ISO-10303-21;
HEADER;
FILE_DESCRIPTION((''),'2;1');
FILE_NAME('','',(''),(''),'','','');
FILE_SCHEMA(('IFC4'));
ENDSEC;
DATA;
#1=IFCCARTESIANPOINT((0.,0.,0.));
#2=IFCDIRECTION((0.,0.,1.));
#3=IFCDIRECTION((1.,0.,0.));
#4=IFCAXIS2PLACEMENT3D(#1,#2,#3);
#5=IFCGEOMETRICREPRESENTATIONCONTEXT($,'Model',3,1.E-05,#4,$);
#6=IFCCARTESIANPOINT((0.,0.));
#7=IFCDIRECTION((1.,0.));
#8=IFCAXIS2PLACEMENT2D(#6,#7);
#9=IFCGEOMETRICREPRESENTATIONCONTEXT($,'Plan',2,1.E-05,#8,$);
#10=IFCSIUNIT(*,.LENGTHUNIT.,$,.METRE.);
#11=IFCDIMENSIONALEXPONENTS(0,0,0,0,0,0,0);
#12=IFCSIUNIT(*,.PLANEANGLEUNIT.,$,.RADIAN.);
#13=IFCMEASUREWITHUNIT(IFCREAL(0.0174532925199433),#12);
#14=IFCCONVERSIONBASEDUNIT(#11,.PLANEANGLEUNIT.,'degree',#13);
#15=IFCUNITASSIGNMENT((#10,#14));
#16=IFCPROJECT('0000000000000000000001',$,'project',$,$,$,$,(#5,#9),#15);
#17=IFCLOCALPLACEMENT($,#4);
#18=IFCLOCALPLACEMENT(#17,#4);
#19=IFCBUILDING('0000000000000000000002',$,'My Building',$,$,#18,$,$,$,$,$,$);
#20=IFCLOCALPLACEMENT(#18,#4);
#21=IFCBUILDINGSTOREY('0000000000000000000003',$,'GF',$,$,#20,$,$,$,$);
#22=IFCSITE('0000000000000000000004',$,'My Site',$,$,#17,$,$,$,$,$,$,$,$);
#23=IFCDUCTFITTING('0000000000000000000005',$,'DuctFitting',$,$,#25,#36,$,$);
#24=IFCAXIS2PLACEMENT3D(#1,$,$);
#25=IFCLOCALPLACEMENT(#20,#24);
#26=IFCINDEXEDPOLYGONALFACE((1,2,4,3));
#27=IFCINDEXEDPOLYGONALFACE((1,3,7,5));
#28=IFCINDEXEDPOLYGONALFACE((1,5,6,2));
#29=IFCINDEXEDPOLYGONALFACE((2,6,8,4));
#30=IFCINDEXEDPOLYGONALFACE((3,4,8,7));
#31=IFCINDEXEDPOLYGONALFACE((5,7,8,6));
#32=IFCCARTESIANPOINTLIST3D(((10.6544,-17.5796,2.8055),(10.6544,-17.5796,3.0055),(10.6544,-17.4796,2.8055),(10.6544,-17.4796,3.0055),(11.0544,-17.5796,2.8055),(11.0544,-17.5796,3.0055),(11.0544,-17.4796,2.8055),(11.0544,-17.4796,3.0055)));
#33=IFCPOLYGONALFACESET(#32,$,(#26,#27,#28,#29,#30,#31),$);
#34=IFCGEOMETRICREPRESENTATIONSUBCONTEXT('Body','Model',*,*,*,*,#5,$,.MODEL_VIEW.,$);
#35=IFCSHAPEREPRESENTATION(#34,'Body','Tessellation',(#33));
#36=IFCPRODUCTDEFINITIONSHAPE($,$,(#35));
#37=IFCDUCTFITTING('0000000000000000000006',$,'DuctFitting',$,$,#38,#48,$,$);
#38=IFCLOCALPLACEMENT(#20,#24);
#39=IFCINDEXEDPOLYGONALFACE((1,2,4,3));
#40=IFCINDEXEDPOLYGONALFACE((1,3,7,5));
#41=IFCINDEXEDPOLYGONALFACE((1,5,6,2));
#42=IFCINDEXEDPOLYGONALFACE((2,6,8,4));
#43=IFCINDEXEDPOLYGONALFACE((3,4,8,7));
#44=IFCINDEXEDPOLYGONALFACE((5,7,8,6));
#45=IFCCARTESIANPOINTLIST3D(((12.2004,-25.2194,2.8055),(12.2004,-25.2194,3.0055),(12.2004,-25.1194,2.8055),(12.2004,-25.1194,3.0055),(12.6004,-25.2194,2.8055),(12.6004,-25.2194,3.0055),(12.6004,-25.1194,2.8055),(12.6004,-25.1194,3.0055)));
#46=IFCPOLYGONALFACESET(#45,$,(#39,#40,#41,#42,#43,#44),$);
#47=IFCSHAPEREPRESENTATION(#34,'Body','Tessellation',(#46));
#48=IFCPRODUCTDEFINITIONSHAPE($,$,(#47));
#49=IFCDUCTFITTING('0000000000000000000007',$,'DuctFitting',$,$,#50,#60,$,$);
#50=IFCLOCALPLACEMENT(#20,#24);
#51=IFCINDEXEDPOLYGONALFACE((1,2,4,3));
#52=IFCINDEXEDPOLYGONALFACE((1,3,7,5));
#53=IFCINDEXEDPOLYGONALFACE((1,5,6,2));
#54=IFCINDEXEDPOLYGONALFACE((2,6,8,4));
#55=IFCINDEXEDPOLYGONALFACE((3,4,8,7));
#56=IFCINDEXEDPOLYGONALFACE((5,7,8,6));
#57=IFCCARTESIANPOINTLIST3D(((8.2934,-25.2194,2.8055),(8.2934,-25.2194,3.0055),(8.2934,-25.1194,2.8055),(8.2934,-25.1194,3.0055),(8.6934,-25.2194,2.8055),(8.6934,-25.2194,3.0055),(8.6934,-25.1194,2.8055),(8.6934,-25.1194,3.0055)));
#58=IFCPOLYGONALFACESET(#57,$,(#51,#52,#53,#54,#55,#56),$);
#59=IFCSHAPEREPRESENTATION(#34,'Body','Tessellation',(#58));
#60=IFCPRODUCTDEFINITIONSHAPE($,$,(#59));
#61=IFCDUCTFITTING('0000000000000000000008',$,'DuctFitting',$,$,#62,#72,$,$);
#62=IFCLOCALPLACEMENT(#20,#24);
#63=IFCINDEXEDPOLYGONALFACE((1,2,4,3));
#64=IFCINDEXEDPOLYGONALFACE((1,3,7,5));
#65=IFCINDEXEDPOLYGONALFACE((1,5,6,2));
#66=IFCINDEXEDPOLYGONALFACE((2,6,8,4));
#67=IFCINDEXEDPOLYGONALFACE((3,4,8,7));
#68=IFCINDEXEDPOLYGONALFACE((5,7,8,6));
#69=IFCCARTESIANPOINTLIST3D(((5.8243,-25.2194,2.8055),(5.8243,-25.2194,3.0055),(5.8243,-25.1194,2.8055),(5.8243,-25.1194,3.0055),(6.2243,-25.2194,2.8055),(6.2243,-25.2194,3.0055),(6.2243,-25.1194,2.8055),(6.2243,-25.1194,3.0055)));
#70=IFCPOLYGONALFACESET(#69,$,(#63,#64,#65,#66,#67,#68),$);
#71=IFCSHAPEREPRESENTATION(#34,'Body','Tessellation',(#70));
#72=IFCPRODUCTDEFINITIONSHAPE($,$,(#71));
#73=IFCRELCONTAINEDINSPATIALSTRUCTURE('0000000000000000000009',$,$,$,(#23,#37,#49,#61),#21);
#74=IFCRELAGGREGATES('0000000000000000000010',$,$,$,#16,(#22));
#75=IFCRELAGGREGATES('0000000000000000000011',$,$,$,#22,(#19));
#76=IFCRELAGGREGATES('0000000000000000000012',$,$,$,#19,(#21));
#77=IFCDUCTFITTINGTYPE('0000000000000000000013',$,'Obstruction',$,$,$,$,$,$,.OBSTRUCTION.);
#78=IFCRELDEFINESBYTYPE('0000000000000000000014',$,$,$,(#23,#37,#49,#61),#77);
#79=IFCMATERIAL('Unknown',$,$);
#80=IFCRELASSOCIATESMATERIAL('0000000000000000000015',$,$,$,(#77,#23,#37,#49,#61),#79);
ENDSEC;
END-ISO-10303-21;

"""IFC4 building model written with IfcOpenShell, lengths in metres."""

from ifc_helpers import new_model, entity, si_unit, converted_unit, frame, origin_with_axes, origin_2d_with_axis, place, context, subcontext, project, spatial, rectangle, extrude, material, material_profile, profile_set, profile_usage, type_object, element, save


model = new_model("IFC4")

# Units and contexts
model_context = context("Model", 3, precision=1e-05, world=origin_with_axes())
plan_context = context("Plan", 2, precision=1e-05, world=origin_2d_with_axis())
body_context_1 = subcontext(model_context, "Body", "Model", "MODEL_VIEW")
ifc_project = project(units=[si_unit("LENGTHUNIT", "METRE"), converted_unit("PLANEANGLEUNIT", "degree", entity("IfcReal", 0.0174532925199433), si_unit("PLANEANGLEUNIT", "RADIAN"), dimensions=[0, 0, 0, 0, 0, 0, 0])], contexts=[model_context, plan_context])

# Site, building, storey
site_placement = place(None, origin_with_axes())
site = spatial("IfcSite", under=ifc_project, at=site_placement, Name="My Site")
building_placement = place(site_placement, origin_with_axes())
building = spatial("IfcBuilding", under=site, at=building_placement, Name="My Building")
storey_placement = place(building_placement, origin_with_axes())
storey = spatial("IfcBuildingStorey", under=building, at=storey_placement, Name="GF")

# Shared definitions
ifc_material = material(Name="Unknown")

# Duct fittings
ifc_material_profile = material_profile(ifc_material, rectangle(XDim=0.4, YDim=0.2))
ifc_profile_set = profile_set([ifc_material_profile])
duct_fitting_type = type_object("IfcDuctFittingType", Name="Obstruction", PredefinedType="OBSTRUCTION", material=ifc_profile_set)
ifc_profile_usage_1 = profile_usage(ifc_profile_set, cardinal=5)
duct_fitting_1_placement = place(storey_placement, frame((10.8544, -17.5796, 2.9055), z_axis=(0.0, 1.0, 0.0), x_axis=(-1.0, 0.0, 0.0)))
element("IfcDuctFitting", 1, at=duct_fitting_1_placement, inside=storey, type_object=duct_fitting_type, material=ifc_profile_usage_1, Name="DuctFitting", context=body_context_1, shape_type="SweptSolid", body=[
    extrude(rectangle(XDim=0.4, YDim=0.2), origin_with_axes(), (0.0, 0.0, 1.0), 0.1),
])
ifc_profile_usage_2 = profile_usage(ifc_profile_set, cardinal=5)
duct_fitting_2_placement = place(storey_placement, frame((12.4004, -25.1194, 2.9055), z_axis=(0.0, -1.0, 0.0), x_axis=(1.0, 0.0, 0.0)))
element("IfcDuctFitting", 2, at=duct_fitting_2_placement, inside=storey, type_object=duct_fitting_type, material=ifc_profile_usage_2, Name="DuctFitting", context=body_context_1, shape_type="SweptSolid", body=[
    extrude(rectangle(XDim=0.4, YDim=0.2), origin_with_axes(), (0.0, 0.0, 1.0), 0.1),
])
ifc_profile_usage_3 = profile_usage(ifc_profile_set, cardinal=5)
duct_fitting_3_placement = place(storey_placement, frame((8.4934, -25.1194, 2.9055), z_axis=(0.0, -1.0, 0.0), x_axis=(1.0, 0.0, 0.0)))
element("IfcDuctFitting", 3, at=duct_fitting_3_placement, inside=storey, type_object=duct_fitting_type, material=ifc_profile_usage_3, Name="DuctFitting", context=body_context_1, shape_type="SweptSolid", body=[
    extrude(rectangle(XDim=0.4, YDim=0.2), origin_with_axes(), (0.0, 0.0, 1.0), 0.1),
])
ifc_profile_usage_4 = profile_usage(ifc_profile_set, cardinal=5)
duct_fitting_4_placement = place(storey_placement, frame((6.0243, -25.1194, 2.9055), z_axis=(0.0, -1.0, 0.0), x_axis=(1.0, 0.0, 0.0)))
element("IfcDuctFitting", 4, at=duct_fitting_4_placement, inside=storey, type_object=duct_fitting_type, material=ifc_profile_usage_4, Name="DuctFitting", context=body_context_1, shape_type="SweptSolid", body=[
    extrude(rectangle(XDim=0.4, YDim=0.2), origin_with_axes(), (0.0, 0.0, 1.0), 0.1),
])

save(model, "model.ifc")
